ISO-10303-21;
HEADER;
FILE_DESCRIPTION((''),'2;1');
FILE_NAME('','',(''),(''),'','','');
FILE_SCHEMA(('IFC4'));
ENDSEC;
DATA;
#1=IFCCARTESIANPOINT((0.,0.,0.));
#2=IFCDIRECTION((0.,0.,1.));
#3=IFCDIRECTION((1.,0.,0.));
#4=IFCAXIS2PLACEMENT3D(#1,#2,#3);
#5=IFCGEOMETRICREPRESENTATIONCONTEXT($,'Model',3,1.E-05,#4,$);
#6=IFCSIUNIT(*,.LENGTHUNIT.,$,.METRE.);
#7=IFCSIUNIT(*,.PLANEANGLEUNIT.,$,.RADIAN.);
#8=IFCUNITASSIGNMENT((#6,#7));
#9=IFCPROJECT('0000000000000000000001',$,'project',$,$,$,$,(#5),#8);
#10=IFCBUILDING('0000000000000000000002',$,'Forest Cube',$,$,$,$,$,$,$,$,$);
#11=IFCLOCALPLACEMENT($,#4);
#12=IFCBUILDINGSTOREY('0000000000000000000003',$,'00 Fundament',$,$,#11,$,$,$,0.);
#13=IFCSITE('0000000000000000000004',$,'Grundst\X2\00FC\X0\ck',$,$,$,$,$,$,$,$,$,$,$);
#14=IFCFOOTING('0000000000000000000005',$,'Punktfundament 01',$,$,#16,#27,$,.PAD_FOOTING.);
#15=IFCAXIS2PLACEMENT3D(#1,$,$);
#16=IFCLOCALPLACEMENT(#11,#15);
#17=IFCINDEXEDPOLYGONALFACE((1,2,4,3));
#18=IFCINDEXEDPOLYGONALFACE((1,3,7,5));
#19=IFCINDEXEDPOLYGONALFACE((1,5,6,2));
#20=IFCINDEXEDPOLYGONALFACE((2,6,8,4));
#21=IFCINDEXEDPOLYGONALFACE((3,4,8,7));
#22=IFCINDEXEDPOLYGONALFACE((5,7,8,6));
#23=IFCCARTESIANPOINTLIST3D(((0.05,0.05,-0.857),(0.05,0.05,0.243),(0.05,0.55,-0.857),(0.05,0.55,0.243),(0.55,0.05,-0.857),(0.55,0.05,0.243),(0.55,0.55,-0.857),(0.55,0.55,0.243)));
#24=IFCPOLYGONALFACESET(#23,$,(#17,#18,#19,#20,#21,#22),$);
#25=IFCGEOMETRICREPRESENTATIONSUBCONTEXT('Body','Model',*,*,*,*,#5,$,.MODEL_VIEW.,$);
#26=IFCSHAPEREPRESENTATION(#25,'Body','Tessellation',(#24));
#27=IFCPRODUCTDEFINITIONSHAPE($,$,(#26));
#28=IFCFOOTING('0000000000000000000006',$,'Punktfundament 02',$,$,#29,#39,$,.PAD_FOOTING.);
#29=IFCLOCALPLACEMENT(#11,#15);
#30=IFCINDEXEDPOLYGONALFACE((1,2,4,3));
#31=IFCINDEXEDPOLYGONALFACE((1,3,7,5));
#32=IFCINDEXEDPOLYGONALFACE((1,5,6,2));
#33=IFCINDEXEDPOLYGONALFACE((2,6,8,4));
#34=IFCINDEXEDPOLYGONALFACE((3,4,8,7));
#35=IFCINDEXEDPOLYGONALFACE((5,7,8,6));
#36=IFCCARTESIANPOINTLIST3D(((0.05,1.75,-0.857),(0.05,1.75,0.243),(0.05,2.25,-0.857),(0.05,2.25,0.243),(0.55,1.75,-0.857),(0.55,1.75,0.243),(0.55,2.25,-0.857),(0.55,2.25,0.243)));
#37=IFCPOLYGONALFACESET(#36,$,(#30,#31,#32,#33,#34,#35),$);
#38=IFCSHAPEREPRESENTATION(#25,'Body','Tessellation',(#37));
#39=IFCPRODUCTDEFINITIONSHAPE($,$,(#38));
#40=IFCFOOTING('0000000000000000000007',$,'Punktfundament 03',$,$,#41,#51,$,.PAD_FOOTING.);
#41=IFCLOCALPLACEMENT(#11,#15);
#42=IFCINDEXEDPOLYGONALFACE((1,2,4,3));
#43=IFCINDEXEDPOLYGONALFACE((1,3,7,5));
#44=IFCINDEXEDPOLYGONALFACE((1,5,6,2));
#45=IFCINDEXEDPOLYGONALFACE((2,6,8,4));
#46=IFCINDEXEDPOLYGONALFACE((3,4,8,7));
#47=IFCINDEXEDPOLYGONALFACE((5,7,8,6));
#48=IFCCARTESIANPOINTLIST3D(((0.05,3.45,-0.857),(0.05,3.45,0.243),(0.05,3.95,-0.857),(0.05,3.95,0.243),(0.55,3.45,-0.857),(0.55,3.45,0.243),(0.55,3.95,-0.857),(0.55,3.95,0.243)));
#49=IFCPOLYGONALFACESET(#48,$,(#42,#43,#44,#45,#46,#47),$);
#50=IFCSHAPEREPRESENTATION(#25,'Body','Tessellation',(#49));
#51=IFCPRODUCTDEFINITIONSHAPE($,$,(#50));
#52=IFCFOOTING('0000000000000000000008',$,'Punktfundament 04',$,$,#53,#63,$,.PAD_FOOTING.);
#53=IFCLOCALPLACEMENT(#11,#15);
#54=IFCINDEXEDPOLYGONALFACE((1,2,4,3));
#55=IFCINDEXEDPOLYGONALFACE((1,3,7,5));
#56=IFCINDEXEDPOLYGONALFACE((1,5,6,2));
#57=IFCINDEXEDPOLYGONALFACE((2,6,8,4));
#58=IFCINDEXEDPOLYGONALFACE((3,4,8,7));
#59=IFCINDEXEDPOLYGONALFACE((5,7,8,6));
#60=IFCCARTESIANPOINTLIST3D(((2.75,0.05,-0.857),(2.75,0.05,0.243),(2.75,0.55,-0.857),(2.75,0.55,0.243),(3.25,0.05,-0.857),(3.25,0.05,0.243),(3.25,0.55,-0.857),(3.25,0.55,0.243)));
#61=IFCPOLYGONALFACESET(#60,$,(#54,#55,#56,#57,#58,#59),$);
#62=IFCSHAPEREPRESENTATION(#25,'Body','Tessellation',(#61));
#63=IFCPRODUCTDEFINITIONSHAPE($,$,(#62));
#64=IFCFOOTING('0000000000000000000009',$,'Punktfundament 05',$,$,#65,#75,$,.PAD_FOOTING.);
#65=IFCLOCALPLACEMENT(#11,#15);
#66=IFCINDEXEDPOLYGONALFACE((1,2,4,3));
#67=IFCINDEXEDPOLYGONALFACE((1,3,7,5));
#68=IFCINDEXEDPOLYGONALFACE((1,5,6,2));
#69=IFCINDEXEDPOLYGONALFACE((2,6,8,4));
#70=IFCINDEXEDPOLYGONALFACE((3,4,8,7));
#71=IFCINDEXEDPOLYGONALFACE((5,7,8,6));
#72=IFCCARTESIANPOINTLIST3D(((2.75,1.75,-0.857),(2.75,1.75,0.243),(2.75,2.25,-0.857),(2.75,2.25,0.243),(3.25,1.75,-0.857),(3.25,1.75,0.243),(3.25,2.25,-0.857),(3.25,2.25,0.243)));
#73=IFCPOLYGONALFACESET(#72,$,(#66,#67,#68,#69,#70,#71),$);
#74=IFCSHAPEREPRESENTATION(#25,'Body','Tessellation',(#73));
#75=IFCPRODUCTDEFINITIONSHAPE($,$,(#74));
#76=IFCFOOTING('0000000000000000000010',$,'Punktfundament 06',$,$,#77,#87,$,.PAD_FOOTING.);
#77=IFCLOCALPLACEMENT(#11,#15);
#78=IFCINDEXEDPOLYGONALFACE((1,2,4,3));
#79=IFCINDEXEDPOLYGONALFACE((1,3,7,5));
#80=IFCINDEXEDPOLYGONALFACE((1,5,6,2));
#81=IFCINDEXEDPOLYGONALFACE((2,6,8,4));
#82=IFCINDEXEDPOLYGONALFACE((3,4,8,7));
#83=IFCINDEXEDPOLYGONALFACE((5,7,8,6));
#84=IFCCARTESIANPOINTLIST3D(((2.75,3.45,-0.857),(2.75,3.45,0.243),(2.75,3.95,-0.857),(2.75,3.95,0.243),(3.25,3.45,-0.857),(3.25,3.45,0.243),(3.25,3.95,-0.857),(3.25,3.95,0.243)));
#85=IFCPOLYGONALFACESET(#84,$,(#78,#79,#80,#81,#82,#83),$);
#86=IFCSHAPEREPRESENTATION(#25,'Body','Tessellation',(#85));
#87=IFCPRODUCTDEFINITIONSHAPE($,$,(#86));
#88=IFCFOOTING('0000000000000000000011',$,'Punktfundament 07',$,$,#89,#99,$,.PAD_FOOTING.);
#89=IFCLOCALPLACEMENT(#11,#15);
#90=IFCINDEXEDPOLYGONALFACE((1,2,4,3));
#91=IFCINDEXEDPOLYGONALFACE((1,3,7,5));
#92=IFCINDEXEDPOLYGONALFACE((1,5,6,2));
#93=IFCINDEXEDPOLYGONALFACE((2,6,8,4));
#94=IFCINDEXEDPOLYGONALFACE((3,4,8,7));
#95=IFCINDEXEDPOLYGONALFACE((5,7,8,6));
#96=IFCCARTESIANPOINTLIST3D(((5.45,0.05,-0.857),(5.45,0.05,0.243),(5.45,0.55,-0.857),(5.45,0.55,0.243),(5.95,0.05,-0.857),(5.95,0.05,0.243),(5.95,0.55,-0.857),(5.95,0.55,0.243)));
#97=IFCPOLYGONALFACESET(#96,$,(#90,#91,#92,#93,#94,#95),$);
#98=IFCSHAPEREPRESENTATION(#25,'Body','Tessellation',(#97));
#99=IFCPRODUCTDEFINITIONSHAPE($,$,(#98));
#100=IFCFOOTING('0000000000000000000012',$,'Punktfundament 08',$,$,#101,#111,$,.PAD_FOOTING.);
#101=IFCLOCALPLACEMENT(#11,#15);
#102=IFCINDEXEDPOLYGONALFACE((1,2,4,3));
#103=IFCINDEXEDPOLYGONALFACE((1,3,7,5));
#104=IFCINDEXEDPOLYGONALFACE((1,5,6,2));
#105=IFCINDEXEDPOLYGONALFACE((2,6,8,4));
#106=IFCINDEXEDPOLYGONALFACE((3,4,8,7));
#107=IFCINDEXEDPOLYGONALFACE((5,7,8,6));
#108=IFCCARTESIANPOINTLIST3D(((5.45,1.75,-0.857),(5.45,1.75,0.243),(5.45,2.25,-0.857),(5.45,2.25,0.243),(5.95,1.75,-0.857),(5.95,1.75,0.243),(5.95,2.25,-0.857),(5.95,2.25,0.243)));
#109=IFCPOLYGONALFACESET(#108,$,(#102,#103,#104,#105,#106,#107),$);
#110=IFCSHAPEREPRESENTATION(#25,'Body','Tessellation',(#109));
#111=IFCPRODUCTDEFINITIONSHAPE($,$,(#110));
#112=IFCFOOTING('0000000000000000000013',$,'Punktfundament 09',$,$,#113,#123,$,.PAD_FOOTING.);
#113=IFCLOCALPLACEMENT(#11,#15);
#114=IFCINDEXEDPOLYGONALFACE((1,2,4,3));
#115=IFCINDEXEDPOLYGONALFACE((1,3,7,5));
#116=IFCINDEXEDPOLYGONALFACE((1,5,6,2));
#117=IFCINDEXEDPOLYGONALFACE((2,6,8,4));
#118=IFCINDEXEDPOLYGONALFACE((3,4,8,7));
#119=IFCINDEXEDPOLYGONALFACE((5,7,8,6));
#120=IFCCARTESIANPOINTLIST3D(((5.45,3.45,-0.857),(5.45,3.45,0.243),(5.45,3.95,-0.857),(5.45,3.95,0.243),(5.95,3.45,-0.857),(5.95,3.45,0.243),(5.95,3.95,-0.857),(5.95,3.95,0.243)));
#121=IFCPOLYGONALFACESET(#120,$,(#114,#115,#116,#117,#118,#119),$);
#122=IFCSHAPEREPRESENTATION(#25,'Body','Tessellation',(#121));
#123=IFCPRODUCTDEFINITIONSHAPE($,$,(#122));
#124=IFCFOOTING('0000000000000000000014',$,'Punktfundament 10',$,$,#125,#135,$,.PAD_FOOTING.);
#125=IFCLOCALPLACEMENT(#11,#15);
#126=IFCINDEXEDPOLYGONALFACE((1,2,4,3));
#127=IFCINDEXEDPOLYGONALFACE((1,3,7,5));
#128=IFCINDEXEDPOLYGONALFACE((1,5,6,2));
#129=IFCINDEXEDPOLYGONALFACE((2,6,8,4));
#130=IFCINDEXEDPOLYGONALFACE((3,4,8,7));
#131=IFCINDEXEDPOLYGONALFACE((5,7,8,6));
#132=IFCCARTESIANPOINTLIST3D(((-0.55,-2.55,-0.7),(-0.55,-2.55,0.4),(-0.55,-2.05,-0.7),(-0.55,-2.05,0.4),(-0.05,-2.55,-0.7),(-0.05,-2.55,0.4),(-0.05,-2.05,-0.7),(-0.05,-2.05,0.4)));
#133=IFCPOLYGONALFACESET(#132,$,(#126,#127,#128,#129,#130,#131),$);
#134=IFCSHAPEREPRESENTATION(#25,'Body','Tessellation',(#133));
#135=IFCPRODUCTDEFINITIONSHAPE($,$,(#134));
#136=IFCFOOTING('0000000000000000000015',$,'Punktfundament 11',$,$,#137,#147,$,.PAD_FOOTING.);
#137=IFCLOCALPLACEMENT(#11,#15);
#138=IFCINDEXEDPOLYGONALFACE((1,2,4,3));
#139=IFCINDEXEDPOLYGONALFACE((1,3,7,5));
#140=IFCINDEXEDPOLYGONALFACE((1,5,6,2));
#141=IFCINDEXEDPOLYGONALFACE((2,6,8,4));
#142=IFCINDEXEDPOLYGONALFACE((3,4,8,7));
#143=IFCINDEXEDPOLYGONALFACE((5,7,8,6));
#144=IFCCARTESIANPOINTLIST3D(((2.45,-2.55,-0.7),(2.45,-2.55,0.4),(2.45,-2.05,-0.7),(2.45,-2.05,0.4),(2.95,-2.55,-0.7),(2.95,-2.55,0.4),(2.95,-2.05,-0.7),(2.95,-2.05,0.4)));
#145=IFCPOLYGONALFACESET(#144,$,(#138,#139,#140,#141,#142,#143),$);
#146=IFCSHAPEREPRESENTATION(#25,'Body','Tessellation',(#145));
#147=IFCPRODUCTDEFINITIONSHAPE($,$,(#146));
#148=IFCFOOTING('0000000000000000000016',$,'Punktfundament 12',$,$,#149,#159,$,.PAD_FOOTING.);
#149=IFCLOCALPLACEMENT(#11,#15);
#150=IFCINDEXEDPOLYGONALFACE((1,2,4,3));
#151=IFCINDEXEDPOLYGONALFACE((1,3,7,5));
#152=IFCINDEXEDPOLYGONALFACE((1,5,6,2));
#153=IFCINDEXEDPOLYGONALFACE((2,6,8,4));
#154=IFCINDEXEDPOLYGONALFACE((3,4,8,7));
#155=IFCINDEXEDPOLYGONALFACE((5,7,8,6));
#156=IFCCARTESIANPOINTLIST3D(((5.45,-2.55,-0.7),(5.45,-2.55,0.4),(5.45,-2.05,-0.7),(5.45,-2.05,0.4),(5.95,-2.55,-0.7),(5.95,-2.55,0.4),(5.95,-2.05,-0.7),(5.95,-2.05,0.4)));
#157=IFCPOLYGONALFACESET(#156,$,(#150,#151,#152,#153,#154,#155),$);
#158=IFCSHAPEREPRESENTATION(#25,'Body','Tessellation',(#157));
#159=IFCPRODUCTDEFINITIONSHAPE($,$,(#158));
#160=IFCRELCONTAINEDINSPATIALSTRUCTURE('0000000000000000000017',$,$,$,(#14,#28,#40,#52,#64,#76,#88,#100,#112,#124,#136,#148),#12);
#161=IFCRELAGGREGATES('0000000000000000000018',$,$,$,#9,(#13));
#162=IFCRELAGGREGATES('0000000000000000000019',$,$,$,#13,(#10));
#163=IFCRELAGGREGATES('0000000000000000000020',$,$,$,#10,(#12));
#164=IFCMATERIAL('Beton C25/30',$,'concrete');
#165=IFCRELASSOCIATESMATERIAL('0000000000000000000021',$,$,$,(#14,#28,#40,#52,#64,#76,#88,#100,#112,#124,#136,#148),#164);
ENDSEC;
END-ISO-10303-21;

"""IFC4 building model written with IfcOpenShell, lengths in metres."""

from ifc_helpers import new_model, si_unit, frame, origin_with_axes, place, context, subcontext, project, spatial, indexed_curve, outline, extrude, material, element, save


model = new_model("IFC4")

# Units and contexts
model_context = context("Model", 3, precision=1e-05, world=origin_with_axes())
body_context = subcontext(model_context, "Body", "Model", "MODEL_VIEW")
ifc_project = project(units=[si_unit("LENGTHUNIT", "METRE"), si_unit("PLANEANGLEUNIT", "RADIAN")], contexts=[model_context])

# Site, building, storey
site = spatial("IfcSite", under=ifc_project, Name="Grundstück")
building = spatial("IfcBuilding", under=site, Name="Forest Cube")
storey_placement = place(None, origin_with_axes())
storey = spatial("IfcBuildingStorey", under=building, at=storey_placement, Name="00 Fundament", Elevation=0.0)

# Footings
ifc_material = material(Name="Beton C25/30", Category="concrete")
for number, where, z_axis, x_axis, name in (
    (1, (0.3, 0.3, -0.857), (0.0, 0.0, 1.0), (1.0, 0.0, 0.0), "Punktfundament 01"),
    (2, (0.3, 2.0, -0.857), (0.0, 0.0, 1.0), (1.0, 0.0, 0.0), "Punktfundament 02"),
    (3, (0.3, 3.7, -0.857), (0.0, 0.0, 1.0), (1.0, 0.0, 0.0), "Punktfundament 03"),
    (4, (3.0, 0.3, -0.857), (0.0, 0.0, 1.0), (1.0, 0.0, 0.0), "Punktfundament 04"),
    (5, (3.0, 2.0, -0.857), (0.0, 0.0, 1.0), (1.0, 0.0, 0.0), "Punktfundament 05"),
    (6, (3.0, 3.7, -0.857), (0.0, 0.0, 1.0), (1.0, 0.0, 0.0), "Punktfundament 06"),
    (7, (5.7, 0.3, -0.857), (0.0, 0.0, 1.0), (1.0, 0.0, 0.0), "Punktfundament 07"),
    (8, (5.7, 2.0, -0.857), (0.0, 0.0, 1.0), (1.0, 0.0, 0.0), "Punktfundament 08"),
    (9, (5.7, 3.7, -0.857), (0.0, 0.0, 1.0), (1.0, 0.0, 0.0), "Punktfundament 09"),
    (10, (-0.3, -2.3, -0.7), (0.0, 0.0, 1.0), (1.0, 0.0, 0.0), "Punktfundament 10"),
    (11, (2.7, -2.3, -0.7), (0.0, 0.0, 1.0), (1.0, 0.0, 0.0), "Punktfundament 11"),
    (12, (5.7, -2.3, -0.7), (0.0, 0.0, 1.0), (1.0, 0.0, 0.0), "Punktfundament 12"),
):
    element("IfcFooting", number, at=place(storey_placement, frame(where, z_axis=z_axis, x_axis=x_axis)), inside=storey, material=ifc_material, Name=name, PredefinedType="PAD_FOOTING", context=body_context, shape_type="SweptSolid", body=[
        extrude(outline(indexed_curve([(-0.25, -0.25), (0.25, -0.25), (0.25, 0.25), (-0.25, 0.25)])), None, (0.0, 0.0, 1.0), 1.1),
    ])

save(model, "model.ifc")
